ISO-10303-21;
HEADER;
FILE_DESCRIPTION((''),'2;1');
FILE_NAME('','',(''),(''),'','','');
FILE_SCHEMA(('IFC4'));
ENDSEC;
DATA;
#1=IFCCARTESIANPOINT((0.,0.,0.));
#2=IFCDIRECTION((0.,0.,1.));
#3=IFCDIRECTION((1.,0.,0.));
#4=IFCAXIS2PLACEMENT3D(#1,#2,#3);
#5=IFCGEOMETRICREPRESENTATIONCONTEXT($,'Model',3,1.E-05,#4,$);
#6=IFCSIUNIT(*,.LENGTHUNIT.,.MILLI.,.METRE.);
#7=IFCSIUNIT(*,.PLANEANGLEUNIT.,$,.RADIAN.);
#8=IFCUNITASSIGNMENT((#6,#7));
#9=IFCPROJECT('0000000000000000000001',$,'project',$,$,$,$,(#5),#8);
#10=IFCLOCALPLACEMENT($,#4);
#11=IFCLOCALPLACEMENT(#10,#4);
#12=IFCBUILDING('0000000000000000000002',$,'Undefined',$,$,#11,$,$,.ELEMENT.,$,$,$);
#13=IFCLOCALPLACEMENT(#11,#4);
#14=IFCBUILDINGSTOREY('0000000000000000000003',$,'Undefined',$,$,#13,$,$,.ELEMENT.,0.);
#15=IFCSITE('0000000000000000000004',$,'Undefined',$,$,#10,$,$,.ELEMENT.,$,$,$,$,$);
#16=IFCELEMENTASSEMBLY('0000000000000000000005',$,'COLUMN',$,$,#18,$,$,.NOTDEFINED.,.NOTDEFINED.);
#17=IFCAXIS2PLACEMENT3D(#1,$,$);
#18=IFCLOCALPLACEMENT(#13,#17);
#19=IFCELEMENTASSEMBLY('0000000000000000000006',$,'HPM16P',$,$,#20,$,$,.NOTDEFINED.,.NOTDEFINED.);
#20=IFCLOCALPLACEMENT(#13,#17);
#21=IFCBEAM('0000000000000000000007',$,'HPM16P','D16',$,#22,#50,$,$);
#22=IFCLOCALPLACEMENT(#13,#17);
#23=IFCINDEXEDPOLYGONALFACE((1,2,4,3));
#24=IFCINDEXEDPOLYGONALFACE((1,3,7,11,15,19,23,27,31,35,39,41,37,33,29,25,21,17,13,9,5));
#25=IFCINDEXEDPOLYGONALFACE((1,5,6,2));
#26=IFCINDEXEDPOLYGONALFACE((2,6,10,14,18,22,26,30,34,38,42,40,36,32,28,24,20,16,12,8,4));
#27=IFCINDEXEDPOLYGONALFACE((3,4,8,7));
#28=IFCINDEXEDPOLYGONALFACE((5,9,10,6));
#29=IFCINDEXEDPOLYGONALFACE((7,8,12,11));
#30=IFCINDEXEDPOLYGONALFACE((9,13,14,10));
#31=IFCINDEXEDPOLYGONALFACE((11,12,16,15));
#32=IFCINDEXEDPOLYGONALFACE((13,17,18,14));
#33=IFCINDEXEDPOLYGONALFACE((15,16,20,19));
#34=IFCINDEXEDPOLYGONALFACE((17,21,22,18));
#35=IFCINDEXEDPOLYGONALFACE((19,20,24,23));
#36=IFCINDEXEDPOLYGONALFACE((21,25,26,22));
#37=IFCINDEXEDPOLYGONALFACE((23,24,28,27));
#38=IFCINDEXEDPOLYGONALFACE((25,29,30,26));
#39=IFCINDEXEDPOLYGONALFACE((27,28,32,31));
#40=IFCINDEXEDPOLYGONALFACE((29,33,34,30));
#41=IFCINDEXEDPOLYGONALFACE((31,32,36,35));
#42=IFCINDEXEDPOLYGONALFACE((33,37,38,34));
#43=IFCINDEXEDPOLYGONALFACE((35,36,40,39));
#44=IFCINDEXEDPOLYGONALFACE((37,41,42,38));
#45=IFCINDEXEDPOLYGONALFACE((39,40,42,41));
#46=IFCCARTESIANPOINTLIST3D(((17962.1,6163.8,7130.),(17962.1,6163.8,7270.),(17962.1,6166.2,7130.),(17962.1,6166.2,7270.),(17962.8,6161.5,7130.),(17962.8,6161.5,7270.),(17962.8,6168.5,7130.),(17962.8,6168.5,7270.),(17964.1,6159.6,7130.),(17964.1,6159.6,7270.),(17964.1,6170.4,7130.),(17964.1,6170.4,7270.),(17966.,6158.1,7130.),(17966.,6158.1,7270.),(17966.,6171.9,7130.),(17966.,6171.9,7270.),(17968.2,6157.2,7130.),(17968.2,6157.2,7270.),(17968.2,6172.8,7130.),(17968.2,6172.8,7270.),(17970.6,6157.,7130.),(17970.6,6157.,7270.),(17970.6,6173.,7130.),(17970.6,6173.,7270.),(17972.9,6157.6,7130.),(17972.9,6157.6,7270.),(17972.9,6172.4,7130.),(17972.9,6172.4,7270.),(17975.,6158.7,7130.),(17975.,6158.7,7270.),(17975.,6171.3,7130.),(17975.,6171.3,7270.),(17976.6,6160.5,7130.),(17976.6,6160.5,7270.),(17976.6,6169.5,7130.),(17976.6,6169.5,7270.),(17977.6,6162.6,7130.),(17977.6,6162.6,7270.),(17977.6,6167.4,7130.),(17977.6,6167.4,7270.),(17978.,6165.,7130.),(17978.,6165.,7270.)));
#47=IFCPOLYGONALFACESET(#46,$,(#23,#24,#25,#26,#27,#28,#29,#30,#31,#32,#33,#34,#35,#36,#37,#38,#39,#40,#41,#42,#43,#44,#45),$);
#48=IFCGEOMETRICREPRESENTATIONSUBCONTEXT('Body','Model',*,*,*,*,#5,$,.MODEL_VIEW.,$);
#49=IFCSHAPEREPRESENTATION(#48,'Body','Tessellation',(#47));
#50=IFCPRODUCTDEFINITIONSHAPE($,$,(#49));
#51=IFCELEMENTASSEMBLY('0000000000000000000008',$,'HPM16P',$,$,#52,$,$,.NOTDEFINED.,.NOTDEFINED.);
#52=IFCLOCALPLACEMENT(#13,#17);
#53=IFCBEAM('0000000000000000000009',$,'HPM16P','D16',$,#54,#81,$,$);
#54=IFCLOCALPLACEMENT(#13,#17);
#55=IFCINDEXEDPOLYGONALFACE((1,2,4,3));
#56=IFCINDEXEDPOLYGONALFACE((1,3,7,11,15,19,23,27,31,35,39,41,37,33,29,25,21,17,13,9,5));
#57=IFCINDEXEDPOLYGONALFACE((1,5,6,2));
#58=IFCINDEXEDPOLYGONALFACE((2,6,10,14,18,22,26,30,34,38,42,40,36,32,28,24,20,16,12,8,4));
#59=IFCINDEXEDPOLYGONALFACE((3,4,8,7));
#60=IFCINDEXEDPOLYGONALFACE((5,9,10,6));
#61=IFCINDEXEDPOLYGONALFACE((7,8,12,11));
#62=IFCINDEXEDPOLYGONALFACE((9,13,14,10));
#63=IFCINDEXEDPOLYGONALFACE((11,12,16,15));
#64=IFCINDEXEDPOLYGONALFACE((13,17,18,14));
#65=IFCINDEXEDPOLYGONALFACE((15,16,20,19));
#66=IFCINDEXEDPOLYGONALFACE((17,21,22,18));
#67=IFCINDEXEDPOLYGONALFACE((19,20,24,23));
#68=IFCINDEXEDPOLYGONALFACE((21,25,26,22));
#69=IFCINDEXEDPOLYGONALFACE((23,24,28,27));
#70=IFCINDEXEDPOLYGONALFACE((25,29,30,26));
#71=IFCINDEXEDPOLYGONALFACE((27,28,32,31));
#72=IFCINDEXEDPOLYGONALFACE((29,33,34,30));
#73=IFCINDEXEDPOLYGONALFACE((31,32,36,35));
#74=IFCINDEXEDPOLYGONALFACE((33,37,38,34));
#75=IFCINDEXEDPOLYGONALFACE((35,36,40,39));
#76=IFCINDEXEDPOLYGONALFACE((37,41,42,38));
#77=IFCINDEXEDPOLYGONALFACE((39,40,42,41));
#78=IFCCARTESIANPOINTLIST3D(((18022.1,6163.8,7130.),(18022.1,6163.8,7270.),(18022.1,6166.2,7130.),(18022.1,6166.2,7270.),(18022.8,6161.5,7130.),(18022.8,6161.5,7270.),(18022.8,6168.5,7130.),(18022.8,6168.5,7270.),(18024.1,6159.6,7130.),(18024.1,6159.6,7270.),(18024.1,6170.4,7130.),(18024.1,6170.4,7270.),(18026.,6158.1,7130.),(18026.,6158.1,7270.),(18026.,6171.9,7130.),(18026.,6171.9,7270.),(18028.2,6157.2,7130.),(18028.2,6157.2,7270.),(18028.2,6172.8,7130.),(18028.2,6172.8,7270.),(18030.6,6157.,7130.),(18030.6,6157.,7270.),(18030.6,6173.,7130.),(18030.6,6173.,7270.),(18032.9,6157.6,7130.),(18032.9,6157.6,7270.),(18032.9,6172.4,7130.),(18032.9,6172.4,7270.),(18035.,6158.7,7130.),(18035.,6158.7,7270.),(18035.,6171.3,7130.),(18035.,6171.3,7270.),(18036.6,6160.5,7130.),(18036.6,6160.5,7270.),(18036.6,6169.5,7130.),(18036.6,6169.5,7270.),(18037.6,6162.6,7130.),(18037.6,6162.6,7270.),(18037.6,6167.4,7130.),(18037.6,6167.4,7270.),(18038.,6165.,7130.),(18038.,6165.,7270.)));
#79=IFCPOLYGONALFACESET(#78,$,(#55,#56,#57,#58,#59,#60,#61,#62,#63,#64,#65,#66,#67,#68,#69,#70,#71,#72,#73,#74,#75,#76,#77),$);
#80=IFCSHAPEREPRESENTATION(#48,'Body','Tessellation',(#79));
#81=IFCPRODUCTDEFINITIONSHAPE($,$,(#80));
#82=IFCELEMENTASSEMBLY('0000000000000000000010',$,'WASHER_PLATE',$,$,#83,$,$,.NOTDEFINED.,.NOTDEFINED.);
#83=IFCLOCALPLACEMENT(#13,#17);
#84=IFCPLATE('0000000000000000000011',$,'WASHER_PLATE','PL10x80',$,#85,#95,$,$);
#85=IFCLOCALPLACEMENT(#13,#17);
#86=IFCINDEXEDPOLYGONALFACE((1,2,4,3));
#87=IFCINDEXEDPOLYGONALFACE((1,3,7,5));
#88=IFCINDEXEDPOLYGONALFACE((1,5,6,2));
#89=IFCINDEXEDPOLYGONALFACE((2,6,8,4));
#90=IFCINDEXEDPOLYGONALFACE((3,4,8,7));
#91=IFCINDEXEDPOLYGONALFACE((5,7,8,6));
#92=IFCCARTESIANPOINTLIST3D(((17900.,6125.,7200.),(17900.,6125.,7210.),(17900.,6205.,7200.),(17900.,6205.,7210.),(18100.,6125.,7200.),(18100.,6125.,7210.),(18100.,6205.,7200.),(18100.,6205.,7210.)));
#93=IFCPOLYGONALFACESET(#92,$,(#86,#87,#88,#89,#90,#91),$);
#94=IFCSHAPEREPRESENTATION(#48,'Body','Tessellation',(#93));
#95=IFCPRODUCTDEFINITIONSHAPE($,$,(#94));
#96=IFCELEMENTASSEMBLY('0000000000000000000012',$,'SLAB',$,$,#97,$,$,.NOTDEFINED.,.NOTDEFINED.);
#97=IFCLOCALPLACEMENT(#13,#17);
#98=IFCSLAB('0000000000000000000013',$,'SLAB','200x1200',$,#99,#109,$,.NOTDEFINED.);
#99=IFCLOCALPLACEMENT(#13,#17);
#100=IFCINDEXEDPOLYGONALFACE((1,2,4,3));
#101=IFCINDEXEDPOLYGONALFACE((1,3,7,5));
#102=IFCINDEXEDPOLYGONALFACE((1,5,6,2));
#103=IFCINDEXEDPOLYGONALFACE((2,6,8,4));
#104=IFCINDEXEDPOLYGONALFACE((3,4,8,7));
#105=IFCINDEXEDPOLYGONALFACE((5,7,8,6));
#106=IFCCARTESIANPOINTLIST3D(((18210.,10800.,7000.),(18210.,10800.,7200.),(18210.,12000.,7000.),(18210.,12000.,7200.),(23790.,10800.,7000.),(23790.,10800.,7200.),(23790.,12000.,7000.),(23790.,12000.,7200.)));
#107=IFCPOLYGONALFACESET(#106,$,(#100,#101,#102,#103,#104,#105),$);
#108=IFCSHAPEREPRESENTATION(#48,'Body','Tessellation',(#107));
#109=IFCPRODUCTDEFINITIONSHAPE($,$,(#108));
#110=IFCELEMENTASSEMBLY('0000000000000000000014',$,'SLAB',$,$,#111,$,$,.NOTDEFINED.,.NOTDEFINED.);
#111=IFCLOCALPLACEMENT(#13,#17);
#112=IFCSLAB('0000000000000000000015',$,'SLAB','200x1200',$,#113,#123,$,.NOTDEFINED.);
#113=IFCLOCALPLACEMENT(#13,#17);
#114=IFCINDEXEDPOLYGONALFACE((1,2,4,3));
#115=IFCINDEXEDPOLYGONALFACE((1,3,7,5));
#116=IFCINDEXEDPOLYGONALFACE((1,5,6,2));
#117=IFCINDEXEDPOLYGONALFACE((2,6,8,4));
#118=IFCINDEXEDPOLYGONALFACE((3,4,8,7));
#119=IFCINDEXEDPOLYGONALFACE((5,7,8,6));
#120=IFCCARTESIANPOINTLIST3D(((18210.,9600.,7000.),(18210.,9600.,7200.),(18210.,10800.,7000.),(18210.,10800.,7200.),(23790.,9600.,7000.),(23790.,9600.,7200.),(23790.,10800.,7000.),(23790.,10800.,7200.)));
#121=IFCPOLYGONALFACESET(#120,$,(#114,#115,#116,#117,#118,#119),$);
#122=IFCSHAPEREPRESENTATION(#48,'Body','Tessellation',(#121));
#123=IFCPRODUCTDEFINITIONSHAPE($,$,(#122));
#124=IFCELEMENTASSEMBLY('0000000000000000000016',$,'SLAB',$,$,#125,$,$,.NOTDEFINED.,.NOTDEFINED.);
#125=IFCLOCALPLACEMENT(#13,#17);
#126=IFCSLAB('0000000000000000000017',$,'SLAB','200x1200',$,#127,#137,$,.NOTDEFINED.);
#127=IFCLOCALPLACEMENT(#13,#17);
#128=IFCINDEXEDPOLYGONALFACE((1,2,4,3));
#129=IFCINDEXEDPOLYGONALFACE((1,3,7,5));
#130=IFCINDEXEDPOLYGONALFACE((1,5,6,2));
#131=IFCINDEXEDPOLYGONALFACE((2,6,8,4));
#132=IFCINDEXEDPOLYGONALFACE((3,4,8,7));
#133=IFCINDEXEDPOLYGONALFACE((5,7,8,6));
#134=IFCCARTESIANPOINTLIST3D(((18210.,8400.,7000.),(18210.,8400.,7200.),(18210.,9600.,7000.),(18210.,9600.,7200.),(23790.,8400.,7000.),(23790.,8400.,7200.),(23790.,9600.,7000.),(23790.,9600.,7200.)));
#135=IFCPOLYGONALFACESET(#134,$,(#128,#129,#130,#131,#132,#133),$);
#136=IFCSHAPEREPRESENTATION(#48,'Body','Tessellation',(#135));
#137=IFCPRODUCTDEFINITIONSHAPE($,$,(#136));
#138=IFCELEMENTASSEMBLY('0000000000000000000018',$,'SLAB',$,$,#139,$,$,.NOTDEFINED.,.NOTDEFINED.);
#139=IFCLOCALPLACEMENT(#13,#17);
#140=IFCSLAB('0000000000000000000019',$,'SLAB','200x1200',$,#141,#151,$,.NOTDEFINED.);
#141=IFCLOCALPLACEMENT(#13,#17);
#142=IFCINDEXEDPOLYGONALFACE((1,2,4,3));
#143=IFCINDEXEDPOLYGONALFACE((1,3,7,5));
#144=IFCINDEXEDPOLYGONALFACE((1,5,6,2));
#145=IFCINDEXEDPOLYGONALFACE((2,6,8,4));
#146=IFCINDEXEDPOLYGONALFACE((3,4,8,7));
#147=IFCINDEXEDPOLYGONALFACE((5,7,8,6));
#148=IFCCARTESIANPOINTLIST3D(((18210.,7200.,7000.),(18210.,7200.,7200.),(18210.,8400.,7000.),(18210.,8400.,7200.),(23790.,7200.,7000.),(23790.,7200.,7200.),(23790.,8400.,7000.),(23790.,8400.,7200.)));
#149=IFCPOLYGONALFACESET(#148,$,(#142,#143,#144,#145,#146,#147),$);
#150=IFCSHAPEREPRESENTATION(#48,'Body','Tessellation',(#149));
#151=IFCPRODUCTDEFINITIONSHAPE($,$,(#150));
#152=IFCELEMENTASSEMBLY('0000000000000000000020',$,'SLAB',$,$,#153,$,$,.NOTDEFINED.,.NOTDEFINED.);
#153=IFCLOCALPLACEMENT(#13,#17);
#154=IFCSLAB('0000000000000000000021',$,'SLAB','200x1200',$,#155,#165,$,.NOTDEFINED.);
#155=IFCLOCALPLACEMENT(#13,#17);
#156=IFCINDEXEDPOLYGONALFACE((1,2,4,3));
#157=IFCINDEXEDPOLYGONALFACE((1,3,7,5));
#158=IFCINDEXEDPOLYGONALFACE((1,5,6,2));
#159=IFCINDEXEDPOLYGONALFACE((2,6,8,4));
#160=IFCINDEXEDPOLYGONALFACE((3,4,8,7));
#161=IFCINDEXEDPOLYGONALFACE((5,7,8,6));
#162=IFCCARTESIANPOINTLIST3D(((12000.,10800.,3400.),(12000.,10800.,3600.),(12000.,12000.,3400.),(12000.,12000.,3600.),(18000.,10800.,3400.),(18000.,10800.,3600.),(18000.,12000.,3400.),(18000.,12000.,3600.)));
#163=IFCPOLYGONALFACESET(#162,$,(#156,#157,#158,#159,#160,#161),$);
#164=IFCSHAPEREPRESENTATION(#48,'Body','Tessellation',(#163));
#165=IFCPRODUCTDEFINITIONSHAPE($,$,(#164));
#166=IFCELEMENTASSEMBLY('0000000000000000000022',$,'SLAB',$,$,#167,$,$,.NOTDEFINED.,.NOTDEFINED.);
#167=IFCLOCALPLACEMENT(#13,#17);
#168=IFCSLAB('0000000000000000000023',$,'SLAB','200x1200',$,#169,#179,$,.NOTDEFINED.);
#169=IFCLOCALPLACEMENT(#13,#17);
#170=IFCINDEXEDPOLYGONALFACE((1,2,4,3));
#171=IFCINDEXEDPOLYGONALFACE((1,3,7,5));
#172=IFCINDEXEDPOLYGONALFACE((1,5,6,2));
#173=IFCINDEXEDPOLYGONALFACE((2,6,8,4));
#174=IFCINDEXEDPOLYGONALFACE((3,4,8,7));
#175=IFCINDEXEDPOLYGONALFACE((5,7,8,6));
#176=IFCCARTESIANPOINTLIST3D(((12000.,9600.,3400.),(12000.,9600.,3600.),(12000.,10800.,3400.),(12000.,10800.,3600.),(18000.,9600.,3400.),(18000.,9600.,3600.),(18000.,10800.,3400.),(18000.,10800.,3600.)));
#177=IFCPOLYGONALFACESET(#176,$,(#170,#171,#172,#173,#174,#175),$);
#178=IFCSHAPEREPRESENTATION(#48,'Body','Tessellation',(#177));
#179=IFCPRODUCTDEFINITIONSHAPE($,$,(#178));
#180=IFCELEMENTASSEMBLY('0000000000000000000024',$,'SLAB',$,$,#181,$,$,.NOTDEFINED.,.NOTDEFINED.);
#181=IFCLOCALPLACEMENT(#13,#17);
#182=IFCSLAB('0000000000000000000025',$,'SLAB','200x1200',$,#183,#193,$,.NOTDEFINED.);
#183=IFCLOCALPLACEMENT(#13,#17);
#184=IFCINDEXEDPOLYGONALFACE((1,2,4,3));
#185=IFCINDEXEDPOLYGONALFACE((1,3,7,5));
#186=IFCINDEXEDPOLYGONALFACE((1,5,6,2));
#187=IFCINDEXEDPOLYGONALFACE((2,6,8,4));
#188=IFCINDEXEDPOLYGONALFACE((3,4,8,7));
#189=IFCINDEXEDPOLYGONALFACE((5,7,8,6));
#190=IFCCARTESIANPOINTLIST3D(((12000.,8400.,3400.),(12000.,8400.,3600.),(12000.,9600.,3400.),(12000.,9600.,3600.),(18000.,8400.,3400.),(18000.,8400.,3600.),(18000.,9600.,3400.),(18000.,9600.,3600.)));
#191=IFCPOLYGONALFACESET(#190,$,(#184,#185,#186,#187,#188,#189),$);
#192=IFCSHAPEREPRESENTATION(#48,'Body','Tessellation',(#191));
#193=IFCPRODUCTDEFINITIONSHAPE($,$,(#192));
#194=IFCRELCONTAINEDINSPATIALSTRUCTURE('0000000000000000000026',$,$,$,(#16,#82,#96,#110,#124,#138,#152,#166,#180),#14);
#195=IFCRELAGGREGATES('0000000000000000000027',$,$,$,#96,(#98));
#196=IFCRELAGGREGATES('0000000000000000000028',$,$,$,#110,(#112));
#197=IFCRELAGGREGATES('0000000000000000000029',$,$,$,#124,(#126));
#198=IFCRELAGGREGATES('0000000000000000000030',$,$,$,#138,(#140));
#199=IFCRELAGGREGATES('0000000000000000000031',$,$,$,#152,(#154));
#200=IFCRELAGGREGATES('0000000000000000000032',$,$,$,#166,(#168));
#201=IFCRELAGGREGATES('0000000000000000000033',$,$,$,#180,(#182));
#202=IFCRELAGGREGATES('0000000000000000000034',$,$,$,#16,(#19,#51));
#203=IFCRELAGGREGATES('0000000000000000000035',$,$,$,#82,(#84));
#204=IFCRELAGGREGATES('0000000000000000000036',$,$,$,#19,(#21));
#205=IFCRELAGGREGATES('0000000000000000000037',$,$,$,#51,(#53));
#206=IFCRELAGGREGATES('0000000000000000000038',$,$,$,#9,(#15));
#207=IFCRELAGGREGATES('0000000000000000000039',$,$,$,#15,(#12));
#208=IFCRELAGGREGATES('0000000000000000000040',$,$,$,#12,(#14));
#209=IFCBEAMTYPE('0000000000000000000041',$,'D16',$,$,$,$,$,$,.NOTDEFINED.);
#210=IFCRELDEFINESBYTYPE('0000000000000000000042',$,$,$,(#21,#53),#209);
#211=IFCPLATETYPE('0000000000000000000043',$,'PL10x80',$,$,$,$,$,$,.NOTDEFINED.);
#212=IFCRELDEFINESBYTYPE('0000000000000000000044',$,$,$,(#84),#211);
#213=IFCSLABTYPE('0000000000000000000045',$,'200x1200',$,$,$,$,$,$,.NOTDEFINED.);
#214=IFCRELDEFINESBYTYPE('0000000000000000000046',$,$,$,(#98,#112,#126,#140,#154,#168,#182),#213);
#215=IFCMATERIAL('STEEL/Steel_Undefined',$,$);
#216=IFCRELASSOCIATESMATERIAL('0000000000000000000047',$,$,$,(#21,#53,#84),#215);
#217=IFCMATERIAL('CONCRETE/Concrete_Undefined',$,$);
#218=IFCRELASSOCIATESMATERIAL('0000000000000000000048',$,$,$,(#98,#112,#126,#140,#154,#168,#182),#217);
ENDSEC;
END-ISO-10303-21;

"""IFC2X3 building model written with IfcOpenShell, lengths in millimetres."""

from ifc_helpers import new_model, si_unit, frame, origin_with_axes, origin_2d_with_axis, place, context, subcontext, project, spatial, polyline, circle, outline, extrude, material, type_object, element, aggregate, save


model = new_model("IFC2X3")

# Units and contexts
model_context = context("Model", 3, precision=1e-05, world=origin_with_axes())
body_context = subcontext(model_context, "Body", "Model", "MODEL_VIEW")
ifc_project = project(units=[si_unit("LENGTHUNIT", "METRE", prefix="MILLI"), si_unit("PLANEANGLEUNIT", "RADIAN")], contexts=[model_context])

# Site, building, storey
site_placement = place(None, origin_with_axes())
site = spatial("IfcSite", under=ifc_project, at=site_placement, Name="Undefined", CompositionType="ELEMENT")
building_placement = place(site_placement, origin_with_axes())
building = spatial("IfcBuilding", under=site, at=building_placement, Name="Undefined", CompositionType="ELEMENT")
storey_placement = place(building_placement, origin_with_axes())
storey = spatial("IfcBuildingStorey", under=building, at=storey_placement, Name="Undefined", CompositionType="ELEMENT", Elevation=0.0)

# Element assemblies, beams
assembly_1_placement = place(storey_placement, origin_with_axes())
assembly_1 = element("IfcElementAssembly", 1, at=assembly_1_placement, inside=storey, Name="COLUMN", AssemblyPlace="NOTDEFINED", PredefinedType="NOTDEFINED")
assembly_2_placement = place(assembly_1_placement, origin_with_axes())
assembly_2 = element("IfcElementAssembly", 2, at=assembly_2_placement, Name="HPM16P", AssemblyPlace="NOTDEFINED", PredefinedType="NOTDEFINED")
ifc_material_1 = material(Name="STEEL/Steel_Undefined")
beam_type = type_object("IfcBeamType", Name="D16", PredefinedType="NOTDEFINED")
beam_1_placement = place(assembly_2_placement, frame((17970.0, 6165.0, 7270.0), z_axis=(0.0, 1.0, 0.0), x_axis=(0.0, 0.0, -1.0)))
beam_1 = element("IfcBeam", 3, at=beam_1_placement, type_object=beam_type, material=ifc_material_1, Name="HPM16P", Description="D16", context=body_context, shape_type="SweptSolid", body=[
    extrude(circle(Radius=8.0, at=origin_2d_with_axis()), frame((140.0, 0.0, 0.0), z_axis=(-1.0, 0.0, 0.0), x_axis=(0.0, -1.0, 0.0)), (0.0, 0.0, 1.0), 140.0),
])
assembly_3_placement = place(assembly_1_placement, origin_with_axes())
assembly_3 = element("IfcElementAssembly", 4, at=assembly_3_placement, Name="HPM16P", AssemblyPlace="NOTDEFINED", PredefinedType="NOTDEFINED")
beam_2_placement = place(assembly_3_placement, frame((18030.0, 6165.0, 7270.0), z_axis=(0.0, 1.0, 0.0), x_axis=(0.0, 0.0, -1.0)))
beam_2 = element("IfcBeam", 5, at=beam_2_placement, type_object=beam_type, material=ifc_material_1, Name="HPM16P", Description="D16", context=body_context, shape_type="SweptSolid", body=[
    extrude(circle(Radius=8.0, at=origin_2d_with_axis()), frame((140.0, 0.0, 0.0), z_axis=(-1.0, 0.0, 0.0), x_axis=(0.0, -1.0, 0.0)), (0.0, 0.0, 1.0), 140.0),
])

# Element assembly, plate
assembly_4_placement = place(storey_placement, origin_with_axes())
assembly_4 = element("IfcElementAssembly", 6, at=assembly_4_placement, inside=storey, Name="WASHER_PLATE", AssemblyPlace="NOTDEFINED", PredefinedType="NOTDEFINED")
plate_type_1 = type_object("IfcPlateType", Name="PL10x80", PredefinedType="NOTDEFINED")
plate_1_placement = place(assembly_4_placement, frame((18100.0, 6205.0, 7205.0), z_axis=(0.0, 0.0, -1.0), x_axis=(0.0, -1.0, 0.0)))
plate_1 = element("IfcPlate", 7, at=plate_1_placement, type_object=plate_type_1, material=ifc_material_1, Name="WASHER_PLATE", Description="PL10x80", context=body_context, shape_type="SweptSolid", body=[
    extrude(outline(polyline([(0.0, 0.0), (80.0, 0.0), (80.0, 200.0), (0.0, 200.0), (0.0, 0.0)])), frame((0.0, 0.0, -5.0), z_axis=(0.0, 0.0, 1.0), x_axis=(1.0, 0.0, 0.0)), (0.0, 0.0, 1.0), 10.0),
])

# Element assemblies, slabs
assembly_5_placement = place(storey_placement, origin_with_axes())
assembly_5 = element("IfcElementAssembly", 8, at=assembly_5_placement, inside=storey, Name="SLAB", AssemblyPlace="NOTDEFINED", PredefinedType="NOTDEFINED")
ifc_material_2 = material(Name="CONCRETE/Concrete_Undefined")
slab_type = type_object("IfcSlabType", Name="200x1200", PredefinedType="NOTDEFINED")
slab_1_placement = place(assembly_5_placement, frame((23790.0, 10800.0, 7100.0), z_axis=(0.0, 0.0, 1.0), x_axis=(0.0, 1.0, 0.0)))
slab_1 = element("IfcSlab", 9, at=slab_1_placement, type_object=slab_type, material=ifc_material_2, Name="SLAB", Description="200x1200", PredefinedType="NOTDEFINED", context=body_context, shape_type="SweptSolid", body=[
    extrude(outline(polyline([(0.0, 0.0), (1200.0, 0.0), (1200.0, 5580.0), (0.0, 5580.0), (0.0, 0.0)])), frame((0.0, 0.0, -100.0), z_axis=(0.0, 0.0, 1.0), x_axis=(1.0, 0.0, 0.0)), (0.0, 0.0, 1.0), 200.0),
])
aggregate(assembly_5, [slab_1])
assembly_6_placement = place(storey_placement, origin_with_axes())
assembly_6 = element("IfcElementAssembly", 10, at=assembly_6_placement, inside=storey, Name="SLAB", AssemblyPlace="NOTDEFINED", PredefinedType="NOTDEFINED")
slab_2_placement = place(assembly_6_placement, frame((23790.0, 9600.0, 7100.0), z_axis=(0.0, 0.0, 1.0), x_axis=(0.0, 1.0, 0.0)))
slab_2 = element("IfcSlab", 11, at=slab_2_placement, type_object=slab_type, material=ifc_material_2, Name="SLAB", Description="200x1200", PredefinedType="NOTDEFINED", context=body_context, shape_type="SweptSolid", body=[
    extrude(outline(polyline([(0.0, 0.0), (1200.0, 0.0), (1200.0, 5580.0), (0.0, 5580.0), (0.0, 0.0)])), frame((0.0, 0.0, -100.0), z_axis=(0.0, 0.0, 1.0), x_axis=(1.0, 0.0, 0.0)), (0.0, 0.0, 1.0), 200.0),
])
aggregate(assembly_6, [slab_2])
assembly_7_placement = place(storey_placement, origin_with_axes())
assembly_7 = element("IfcElementAssembly", 12, at=assembly_7_placement, inside=storey, Name="SLAB", AssemblyPlace="NOTDEFINED", PredefinedType="NOTDEFINED")
slab_3_placement = place(assembly_7_placement, frame((23790.0, 8400.0, 7100.0), z_axis=(0.0, 0.0, 1.0), x_axis=(0.0, 1.0, 0.0)))
slab_3 = element("IfcSlab", 13, at=slab_3_placement, type_object=slab_type, material=ifc_material_2, Name="SLAB", Description="200x1200", PredefinedType="NOTDEFINED", context=body_context, shape_type="SweptSolid", body=[
    extrude(outline(polyline([(0.0, 0.0), (1200.0, 0.0), (1200.0, 5580.0), (0.0, 5580.0), (0.0, 0.0)])), frame((0.0, 0.0, -100.0), z_axis=(0.0, 0.0, 1.0), x_axis=(1.0, 0.0, 0.0)), (0.0, 0.0, 1.0), 200.0),
])
aggregate(assembly_7, [slab_3])
assembly_8_placement = place(storey_placement, origin_with_axes())
assembly_8 = element("IfcElementAssembly", 14, at=assembly_8_placement, inside=storey, Name="SLAB", AssemblyPlace="NOTDEFINED", PredefinedType="NOTDEFINED")
slab_4_placement = place(assembly_8_placement, frame((23790.0, 7200.0, 7100.0), z_axis=(0.0, 0.0, 1.0), x_axis=(0.0, 1.0, 0.0)))
slab_4 = element("IfcSlab", 15, at=slab_4_placement, type_object=slab_type, material=ifc_material_2, Name="SLAB", Description="200x1200", PredefinedType="NOTDEFINED", context=body_context, shape_type="SweptSolid", body=[
    extrude(outline(polyline([(0.0, 0.0), (1200.0, 0.0), (1200.0, 5580.0), (0.0, 5580.0), (0.0, 0.0)])), frame((0.0, 0.0, -100.0), z_axis=(0.0, 0.0, 1.0), x_axis=(1.0, 0.0, 0.0)), (0.0, 0.0, 1.0), 200.0),
])
aggregate(assembly_8, [slab_4])
assembly_9_placement = place(storey_placement, origin_with_axes())
assembly_9 = element("IfcElementAssembly", 16, at=assembly_9_placement, inside=storey, Name="SLAB", AssemblyPlace="NOTDEFINED", PredefinedType="NOTDEFINED")
slab_5_placement = place(assembly_9_placement, frame((18000.0, 10800.0, 3500.0), z_axis=(0.0, 0.0, 1.0), x_axis=(0.0, 1.0, 0.0)))
slab_5 = element("IfcSlab", 17, at=slab_5_placement, type_object=slab_type, material=ifc_material_2, Name="SLAB", Description="200x1200", PredefinedType="NOTDEFINED", context=body_context, shape_type="SweptSolid", body=[
    extrude(outline(polyline([(0.0, 0.0), (1200.0, 0.0), (1200.0, 6000.0), (0.0, 6000.0), (0.0, 0.0)])), frame((0.0, 0.0, -100.0), z_axis=(0.0, 0.0, 1.0), x_axis=(1.0, 0.0, 0.0)), (0.0, 0.0, 1.0), 200.0),
])
aggregate(assembly_9, [slab_5])
assembly_10_placement = place(storey_placement, origin_with_axes())
assembly_10 = element("IfcElementAssembly", 18, at=assembly_10_placement, inside=storey, Name="SLAB", AssemblyPlace="NOTDEFINED", PredefinedType="NOTDEFINED")
slab_6_placement = place(assembly_10_placement, frame((18000.0, 9600.0, 3500.0), z_axis=(0.0, 0.0, 1.0), x_axis=(0.0, 1.0, 0.0)))
slab_6 = element("IfcSlab", 19, at=slab_6_placement, type_object=slab_type, material=ifc_material_2, Name="SLAB", Description="200x1200", PredefinedType="NOTDEFINED", context=body_context, shape_type="SweptSolid", body=[
    extrude(outline(polyline([(0.0, 0.0), (1200.0, 0.0), (1200.0, 6000.0), (0.0, 6000.0), (0.0, 0.0)])), frame((0.0, 0.0, -100.0), z_axis=(0.0, 0.0, 1.0), x_axis=(1.0, 0.0, 0.0)), (0.0, 0.0, 1.0), 200.0),
])
aggregate(assembly_10, [slab_6])
assembly_11_placement = place(storey_placement, origin_with_axes())
assembly_11 = element("IfcElementAssembly", 20, at=assembly_11_placement, inside=storey, Name="SLAB", AssemblyPlace="NOTDEFINED", PredefinedType="NOTDEFINED")
slab_7_placement = place(assembly_11_placement, frame((18000.0, 8400.0, 3500.0), z_axis=(0.0, 0.0, 1.0), x_axis=(0.0, 1.0, 0.0)))
slab_7 = element("IfcSlab", 21, at=slab_7_placement, type_object=slab_type, material=ifc_material_2, Name="SLAB", Description="200x1200", PredefinedType="NOTDEFINED", context=body_context, shape_type="SweptSolid", body=[
    extrude(outline(polyline([(0.0, 0.0), (1200.0, 0.0), (1200.0, 6000.0), (0.0, 6000.0), (0.0, 0.0)])), frame((0.0, 0.0, -100.0), z_axis=(0.0, 0.0, 1.0), x_axis=(1.0, 0.0, 0.0)), (0.0, 0.0, 1.0), 200.0),
])
aggregate(assembly_11, [slab_7])

aggregate(assembly_1, [assembly_2, assembly_3])

aggregate(assembly_4, [plate_1])

aggregate(assembly_2, [beam_1])
aggregate(assembly_3, [beam_2])

save(model, "model.ifc")
